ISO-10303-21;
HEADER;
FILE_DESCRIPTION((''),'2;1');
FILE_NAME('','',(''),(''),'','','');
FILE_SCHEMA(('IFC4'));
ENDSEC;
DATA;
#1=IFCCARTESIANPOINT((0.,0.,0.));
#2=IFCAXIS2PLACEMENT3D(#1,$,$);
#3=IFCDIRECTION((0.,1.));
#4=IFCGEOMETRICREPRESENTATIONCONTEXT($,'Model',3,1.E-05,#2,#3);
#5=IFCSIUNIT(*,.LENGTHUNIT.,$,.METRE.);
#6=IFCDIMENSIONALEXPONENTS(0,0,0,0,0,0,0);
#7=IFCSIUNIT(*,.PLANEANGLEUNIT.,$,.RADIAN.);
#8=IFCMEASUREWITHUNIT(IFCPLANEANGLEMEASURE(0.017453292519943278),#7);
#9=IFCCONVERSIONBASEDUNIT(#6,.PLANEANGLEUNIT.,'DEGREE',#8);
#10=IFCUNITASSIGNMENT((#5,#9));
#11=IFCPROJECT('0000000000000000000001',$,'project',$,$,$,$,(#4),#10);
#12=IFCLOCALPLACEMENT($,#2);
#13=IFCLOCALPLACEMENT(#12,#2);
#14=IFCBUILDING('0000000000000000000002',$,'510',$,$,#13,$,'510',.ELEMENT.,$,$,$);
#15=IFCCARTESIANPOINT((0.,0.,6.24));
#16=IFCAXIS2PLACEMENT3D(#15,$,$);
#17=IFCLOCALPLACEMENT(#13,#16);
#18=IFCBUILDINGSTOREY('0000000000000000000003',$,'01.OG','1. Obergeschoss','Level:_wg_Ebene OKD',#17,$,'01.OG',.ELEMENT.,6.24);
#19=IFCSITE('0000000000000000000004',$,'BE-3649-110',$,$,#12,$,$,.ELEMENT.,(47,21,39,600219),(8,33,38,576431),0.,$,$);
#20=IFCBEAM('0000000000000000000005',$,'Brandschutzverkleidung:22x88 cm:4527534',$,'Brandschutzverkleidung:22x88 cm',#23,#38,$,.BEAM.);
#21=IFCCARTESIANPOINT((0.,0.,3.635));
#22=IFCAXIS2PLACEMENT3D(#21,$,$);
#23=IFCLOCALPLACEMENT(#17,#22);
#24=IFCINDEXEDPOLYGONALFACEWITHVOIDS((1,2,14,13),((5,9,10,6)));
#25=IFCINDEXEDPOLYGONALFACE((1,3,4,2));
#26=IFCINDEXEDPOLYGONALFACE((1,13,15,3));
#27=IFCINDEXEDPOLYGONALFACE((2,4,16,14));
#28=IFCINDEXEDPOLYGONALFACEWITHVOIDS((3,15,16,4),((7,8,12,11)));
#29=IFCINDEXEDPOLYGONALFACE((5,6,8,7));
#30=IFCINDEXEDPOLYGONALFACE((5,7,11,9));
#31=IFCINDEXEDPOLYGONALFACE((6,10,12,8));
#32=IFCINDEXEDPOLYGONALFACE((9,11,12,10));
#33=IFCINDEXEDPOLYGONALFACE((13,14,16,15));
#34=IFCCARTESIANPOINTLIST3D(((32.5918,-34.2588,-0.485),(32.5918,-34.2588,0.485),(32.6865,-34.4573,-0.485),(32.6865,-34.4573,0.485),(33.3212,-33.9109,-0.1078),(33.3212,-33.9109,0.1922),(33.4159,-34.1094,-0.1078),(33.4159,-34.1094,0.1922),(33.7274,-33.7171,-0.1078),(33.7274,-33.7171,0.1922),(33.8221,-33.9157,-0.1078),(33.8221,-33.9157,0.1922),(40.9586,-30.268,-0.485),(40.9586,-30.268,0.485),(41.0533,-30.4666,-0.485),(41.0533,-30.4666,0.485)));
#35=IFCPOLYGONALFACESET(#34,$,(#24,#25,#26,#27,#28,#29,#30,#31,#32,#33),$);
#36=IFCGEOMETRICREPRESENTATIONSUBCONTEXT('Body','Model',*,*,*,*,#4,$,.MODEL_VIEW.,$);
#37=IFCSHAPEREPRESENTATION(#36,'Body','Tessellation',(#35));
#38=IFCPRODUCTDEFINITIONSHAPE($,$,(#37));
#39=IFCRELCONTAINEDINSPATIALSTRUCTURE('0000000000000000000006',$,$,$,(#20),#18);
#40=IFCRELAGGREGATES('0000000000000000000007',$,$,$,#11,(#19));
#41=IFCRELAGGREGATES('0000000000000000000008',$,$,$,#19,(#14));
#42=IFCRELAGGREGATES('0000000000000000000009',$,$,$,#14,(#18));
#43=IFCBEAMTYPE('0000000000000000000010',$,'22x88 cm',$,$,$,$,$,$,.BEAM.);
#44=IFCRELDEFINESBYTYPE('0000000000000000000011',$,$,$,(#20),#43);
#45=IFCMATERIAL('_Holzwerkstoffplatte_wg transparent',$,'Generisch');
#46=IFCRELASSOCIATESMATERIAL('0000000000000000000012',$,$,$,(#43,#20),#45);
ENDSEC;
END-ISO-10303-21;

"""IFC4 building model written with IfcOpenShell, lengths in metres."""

from ifc_helpers import new_model, entity, si_unit, converted_unit, direction, frame, origin, place, context, subcontext, project, spatial, indexed_curve, outline, extrude, source, transform, mapped, material, type_object, type_shapes, element, save


model = new_model("IFC4")

# Units and contexts
model_context = context("Model", 3, precision=1e-05, world=origin(), true_north=direction((0.0, 1.0)))
body_context = subcontext(model_context, "Body", "Model", "MODEL_VIEW")
ifc_project = project(units=[si_unit("LENGTHUNIT", "METRE"), converted_unit("PLANEANGLEUNIT", "DEGREE", entity("IfcPlaneAngleMeasure", 0.017453292519943278), si_unit("PLANEANGLEUNIT", "RADIAN"), dimensions=[0, 0, 0, 0, 0, 0, 0])], contexts=[model_context])

# Site, building, storey
site_placement = place(None, origin())
site = spatial("IfcSite", under=ifc_project, at=site_placement, Name="BE-3649-110", CompositionType="ELEMENT", RefLatitude=(47, 21, 39, 600219), RefLongitude=(8, 33, 38, 576431), RefElevation=0.0)
building_placement = place(site_placement, origin())
building = spatial("IfcBuilding", under=site, at=building_placement, Name="510", LongName="510", CompositionType="ELEMENT")
storey_placement = place(building_placement, frame((0.0, 0.0, 6.24)))
storey = spatial("IfcBuildingStorey", under=building, at=storey_placement, Name="01.OG", Description="1. Obergeschoss", ObjectType="Level:_wg_Ebene OKD", LongName="01.OG", CompositionType="ELEMENT", Elevation=6.24)

# Beam
ifc_material_1 = material(Name="_Holzwerkstoffplatte_wg transparent", Category="Generisch")
beam_type_1 = type_object("IfcBeamType", Name="22x88 cm", PredefinedType="BEAM", material=ifc_material_1)
shared_shape_1 = source(origin(), body_context, "Body", "SweptSolid", [
    extrude(outline(indexed_curve([(-4.635, -0.485), (4.6349, -0.485), (4.6349, 0.485), (-4.635, 0.485), (-4.635, -0.485)], self_intersect=False), holes=[indexed_curve([(3.3768, -0.1078), (3.3768, 0.1922), (3.8268, 0.1922), (3.8268, -0.1078), (3.3768, -0.1078)], self_intersect=False)]), frame((36.8699, -32.462, 0.0), z_axis=(-0.430511, 0.902585, 0.0), x_axis=(-0.902585, -0.430511, 0.0)), (0.0, 0.0, 1.0), 0.22),
])
type_shapes(beam_type_1, [shared_shape_1])
beam_1_placement = place(storey_placement, frame((0.0, 0.0, 3.635)))
element("IfcBeam", 1, at=beam_1_placement, inside=storey, type_object=beam_type_1, material=ifc_material_1, Name="Brandschutzverkleidung:22x88 cm:4527534", ObjectType="Brandschutzverkleidung:22x88 cm", PredefinedType="BEAM", context=body_context, shape_type="MappedRepresentation", body=[
    mapped(shared_shape_1, transform((0.0, 0.0, 0.0), scale=1.0)),
])

save(model, "model.ifc")
